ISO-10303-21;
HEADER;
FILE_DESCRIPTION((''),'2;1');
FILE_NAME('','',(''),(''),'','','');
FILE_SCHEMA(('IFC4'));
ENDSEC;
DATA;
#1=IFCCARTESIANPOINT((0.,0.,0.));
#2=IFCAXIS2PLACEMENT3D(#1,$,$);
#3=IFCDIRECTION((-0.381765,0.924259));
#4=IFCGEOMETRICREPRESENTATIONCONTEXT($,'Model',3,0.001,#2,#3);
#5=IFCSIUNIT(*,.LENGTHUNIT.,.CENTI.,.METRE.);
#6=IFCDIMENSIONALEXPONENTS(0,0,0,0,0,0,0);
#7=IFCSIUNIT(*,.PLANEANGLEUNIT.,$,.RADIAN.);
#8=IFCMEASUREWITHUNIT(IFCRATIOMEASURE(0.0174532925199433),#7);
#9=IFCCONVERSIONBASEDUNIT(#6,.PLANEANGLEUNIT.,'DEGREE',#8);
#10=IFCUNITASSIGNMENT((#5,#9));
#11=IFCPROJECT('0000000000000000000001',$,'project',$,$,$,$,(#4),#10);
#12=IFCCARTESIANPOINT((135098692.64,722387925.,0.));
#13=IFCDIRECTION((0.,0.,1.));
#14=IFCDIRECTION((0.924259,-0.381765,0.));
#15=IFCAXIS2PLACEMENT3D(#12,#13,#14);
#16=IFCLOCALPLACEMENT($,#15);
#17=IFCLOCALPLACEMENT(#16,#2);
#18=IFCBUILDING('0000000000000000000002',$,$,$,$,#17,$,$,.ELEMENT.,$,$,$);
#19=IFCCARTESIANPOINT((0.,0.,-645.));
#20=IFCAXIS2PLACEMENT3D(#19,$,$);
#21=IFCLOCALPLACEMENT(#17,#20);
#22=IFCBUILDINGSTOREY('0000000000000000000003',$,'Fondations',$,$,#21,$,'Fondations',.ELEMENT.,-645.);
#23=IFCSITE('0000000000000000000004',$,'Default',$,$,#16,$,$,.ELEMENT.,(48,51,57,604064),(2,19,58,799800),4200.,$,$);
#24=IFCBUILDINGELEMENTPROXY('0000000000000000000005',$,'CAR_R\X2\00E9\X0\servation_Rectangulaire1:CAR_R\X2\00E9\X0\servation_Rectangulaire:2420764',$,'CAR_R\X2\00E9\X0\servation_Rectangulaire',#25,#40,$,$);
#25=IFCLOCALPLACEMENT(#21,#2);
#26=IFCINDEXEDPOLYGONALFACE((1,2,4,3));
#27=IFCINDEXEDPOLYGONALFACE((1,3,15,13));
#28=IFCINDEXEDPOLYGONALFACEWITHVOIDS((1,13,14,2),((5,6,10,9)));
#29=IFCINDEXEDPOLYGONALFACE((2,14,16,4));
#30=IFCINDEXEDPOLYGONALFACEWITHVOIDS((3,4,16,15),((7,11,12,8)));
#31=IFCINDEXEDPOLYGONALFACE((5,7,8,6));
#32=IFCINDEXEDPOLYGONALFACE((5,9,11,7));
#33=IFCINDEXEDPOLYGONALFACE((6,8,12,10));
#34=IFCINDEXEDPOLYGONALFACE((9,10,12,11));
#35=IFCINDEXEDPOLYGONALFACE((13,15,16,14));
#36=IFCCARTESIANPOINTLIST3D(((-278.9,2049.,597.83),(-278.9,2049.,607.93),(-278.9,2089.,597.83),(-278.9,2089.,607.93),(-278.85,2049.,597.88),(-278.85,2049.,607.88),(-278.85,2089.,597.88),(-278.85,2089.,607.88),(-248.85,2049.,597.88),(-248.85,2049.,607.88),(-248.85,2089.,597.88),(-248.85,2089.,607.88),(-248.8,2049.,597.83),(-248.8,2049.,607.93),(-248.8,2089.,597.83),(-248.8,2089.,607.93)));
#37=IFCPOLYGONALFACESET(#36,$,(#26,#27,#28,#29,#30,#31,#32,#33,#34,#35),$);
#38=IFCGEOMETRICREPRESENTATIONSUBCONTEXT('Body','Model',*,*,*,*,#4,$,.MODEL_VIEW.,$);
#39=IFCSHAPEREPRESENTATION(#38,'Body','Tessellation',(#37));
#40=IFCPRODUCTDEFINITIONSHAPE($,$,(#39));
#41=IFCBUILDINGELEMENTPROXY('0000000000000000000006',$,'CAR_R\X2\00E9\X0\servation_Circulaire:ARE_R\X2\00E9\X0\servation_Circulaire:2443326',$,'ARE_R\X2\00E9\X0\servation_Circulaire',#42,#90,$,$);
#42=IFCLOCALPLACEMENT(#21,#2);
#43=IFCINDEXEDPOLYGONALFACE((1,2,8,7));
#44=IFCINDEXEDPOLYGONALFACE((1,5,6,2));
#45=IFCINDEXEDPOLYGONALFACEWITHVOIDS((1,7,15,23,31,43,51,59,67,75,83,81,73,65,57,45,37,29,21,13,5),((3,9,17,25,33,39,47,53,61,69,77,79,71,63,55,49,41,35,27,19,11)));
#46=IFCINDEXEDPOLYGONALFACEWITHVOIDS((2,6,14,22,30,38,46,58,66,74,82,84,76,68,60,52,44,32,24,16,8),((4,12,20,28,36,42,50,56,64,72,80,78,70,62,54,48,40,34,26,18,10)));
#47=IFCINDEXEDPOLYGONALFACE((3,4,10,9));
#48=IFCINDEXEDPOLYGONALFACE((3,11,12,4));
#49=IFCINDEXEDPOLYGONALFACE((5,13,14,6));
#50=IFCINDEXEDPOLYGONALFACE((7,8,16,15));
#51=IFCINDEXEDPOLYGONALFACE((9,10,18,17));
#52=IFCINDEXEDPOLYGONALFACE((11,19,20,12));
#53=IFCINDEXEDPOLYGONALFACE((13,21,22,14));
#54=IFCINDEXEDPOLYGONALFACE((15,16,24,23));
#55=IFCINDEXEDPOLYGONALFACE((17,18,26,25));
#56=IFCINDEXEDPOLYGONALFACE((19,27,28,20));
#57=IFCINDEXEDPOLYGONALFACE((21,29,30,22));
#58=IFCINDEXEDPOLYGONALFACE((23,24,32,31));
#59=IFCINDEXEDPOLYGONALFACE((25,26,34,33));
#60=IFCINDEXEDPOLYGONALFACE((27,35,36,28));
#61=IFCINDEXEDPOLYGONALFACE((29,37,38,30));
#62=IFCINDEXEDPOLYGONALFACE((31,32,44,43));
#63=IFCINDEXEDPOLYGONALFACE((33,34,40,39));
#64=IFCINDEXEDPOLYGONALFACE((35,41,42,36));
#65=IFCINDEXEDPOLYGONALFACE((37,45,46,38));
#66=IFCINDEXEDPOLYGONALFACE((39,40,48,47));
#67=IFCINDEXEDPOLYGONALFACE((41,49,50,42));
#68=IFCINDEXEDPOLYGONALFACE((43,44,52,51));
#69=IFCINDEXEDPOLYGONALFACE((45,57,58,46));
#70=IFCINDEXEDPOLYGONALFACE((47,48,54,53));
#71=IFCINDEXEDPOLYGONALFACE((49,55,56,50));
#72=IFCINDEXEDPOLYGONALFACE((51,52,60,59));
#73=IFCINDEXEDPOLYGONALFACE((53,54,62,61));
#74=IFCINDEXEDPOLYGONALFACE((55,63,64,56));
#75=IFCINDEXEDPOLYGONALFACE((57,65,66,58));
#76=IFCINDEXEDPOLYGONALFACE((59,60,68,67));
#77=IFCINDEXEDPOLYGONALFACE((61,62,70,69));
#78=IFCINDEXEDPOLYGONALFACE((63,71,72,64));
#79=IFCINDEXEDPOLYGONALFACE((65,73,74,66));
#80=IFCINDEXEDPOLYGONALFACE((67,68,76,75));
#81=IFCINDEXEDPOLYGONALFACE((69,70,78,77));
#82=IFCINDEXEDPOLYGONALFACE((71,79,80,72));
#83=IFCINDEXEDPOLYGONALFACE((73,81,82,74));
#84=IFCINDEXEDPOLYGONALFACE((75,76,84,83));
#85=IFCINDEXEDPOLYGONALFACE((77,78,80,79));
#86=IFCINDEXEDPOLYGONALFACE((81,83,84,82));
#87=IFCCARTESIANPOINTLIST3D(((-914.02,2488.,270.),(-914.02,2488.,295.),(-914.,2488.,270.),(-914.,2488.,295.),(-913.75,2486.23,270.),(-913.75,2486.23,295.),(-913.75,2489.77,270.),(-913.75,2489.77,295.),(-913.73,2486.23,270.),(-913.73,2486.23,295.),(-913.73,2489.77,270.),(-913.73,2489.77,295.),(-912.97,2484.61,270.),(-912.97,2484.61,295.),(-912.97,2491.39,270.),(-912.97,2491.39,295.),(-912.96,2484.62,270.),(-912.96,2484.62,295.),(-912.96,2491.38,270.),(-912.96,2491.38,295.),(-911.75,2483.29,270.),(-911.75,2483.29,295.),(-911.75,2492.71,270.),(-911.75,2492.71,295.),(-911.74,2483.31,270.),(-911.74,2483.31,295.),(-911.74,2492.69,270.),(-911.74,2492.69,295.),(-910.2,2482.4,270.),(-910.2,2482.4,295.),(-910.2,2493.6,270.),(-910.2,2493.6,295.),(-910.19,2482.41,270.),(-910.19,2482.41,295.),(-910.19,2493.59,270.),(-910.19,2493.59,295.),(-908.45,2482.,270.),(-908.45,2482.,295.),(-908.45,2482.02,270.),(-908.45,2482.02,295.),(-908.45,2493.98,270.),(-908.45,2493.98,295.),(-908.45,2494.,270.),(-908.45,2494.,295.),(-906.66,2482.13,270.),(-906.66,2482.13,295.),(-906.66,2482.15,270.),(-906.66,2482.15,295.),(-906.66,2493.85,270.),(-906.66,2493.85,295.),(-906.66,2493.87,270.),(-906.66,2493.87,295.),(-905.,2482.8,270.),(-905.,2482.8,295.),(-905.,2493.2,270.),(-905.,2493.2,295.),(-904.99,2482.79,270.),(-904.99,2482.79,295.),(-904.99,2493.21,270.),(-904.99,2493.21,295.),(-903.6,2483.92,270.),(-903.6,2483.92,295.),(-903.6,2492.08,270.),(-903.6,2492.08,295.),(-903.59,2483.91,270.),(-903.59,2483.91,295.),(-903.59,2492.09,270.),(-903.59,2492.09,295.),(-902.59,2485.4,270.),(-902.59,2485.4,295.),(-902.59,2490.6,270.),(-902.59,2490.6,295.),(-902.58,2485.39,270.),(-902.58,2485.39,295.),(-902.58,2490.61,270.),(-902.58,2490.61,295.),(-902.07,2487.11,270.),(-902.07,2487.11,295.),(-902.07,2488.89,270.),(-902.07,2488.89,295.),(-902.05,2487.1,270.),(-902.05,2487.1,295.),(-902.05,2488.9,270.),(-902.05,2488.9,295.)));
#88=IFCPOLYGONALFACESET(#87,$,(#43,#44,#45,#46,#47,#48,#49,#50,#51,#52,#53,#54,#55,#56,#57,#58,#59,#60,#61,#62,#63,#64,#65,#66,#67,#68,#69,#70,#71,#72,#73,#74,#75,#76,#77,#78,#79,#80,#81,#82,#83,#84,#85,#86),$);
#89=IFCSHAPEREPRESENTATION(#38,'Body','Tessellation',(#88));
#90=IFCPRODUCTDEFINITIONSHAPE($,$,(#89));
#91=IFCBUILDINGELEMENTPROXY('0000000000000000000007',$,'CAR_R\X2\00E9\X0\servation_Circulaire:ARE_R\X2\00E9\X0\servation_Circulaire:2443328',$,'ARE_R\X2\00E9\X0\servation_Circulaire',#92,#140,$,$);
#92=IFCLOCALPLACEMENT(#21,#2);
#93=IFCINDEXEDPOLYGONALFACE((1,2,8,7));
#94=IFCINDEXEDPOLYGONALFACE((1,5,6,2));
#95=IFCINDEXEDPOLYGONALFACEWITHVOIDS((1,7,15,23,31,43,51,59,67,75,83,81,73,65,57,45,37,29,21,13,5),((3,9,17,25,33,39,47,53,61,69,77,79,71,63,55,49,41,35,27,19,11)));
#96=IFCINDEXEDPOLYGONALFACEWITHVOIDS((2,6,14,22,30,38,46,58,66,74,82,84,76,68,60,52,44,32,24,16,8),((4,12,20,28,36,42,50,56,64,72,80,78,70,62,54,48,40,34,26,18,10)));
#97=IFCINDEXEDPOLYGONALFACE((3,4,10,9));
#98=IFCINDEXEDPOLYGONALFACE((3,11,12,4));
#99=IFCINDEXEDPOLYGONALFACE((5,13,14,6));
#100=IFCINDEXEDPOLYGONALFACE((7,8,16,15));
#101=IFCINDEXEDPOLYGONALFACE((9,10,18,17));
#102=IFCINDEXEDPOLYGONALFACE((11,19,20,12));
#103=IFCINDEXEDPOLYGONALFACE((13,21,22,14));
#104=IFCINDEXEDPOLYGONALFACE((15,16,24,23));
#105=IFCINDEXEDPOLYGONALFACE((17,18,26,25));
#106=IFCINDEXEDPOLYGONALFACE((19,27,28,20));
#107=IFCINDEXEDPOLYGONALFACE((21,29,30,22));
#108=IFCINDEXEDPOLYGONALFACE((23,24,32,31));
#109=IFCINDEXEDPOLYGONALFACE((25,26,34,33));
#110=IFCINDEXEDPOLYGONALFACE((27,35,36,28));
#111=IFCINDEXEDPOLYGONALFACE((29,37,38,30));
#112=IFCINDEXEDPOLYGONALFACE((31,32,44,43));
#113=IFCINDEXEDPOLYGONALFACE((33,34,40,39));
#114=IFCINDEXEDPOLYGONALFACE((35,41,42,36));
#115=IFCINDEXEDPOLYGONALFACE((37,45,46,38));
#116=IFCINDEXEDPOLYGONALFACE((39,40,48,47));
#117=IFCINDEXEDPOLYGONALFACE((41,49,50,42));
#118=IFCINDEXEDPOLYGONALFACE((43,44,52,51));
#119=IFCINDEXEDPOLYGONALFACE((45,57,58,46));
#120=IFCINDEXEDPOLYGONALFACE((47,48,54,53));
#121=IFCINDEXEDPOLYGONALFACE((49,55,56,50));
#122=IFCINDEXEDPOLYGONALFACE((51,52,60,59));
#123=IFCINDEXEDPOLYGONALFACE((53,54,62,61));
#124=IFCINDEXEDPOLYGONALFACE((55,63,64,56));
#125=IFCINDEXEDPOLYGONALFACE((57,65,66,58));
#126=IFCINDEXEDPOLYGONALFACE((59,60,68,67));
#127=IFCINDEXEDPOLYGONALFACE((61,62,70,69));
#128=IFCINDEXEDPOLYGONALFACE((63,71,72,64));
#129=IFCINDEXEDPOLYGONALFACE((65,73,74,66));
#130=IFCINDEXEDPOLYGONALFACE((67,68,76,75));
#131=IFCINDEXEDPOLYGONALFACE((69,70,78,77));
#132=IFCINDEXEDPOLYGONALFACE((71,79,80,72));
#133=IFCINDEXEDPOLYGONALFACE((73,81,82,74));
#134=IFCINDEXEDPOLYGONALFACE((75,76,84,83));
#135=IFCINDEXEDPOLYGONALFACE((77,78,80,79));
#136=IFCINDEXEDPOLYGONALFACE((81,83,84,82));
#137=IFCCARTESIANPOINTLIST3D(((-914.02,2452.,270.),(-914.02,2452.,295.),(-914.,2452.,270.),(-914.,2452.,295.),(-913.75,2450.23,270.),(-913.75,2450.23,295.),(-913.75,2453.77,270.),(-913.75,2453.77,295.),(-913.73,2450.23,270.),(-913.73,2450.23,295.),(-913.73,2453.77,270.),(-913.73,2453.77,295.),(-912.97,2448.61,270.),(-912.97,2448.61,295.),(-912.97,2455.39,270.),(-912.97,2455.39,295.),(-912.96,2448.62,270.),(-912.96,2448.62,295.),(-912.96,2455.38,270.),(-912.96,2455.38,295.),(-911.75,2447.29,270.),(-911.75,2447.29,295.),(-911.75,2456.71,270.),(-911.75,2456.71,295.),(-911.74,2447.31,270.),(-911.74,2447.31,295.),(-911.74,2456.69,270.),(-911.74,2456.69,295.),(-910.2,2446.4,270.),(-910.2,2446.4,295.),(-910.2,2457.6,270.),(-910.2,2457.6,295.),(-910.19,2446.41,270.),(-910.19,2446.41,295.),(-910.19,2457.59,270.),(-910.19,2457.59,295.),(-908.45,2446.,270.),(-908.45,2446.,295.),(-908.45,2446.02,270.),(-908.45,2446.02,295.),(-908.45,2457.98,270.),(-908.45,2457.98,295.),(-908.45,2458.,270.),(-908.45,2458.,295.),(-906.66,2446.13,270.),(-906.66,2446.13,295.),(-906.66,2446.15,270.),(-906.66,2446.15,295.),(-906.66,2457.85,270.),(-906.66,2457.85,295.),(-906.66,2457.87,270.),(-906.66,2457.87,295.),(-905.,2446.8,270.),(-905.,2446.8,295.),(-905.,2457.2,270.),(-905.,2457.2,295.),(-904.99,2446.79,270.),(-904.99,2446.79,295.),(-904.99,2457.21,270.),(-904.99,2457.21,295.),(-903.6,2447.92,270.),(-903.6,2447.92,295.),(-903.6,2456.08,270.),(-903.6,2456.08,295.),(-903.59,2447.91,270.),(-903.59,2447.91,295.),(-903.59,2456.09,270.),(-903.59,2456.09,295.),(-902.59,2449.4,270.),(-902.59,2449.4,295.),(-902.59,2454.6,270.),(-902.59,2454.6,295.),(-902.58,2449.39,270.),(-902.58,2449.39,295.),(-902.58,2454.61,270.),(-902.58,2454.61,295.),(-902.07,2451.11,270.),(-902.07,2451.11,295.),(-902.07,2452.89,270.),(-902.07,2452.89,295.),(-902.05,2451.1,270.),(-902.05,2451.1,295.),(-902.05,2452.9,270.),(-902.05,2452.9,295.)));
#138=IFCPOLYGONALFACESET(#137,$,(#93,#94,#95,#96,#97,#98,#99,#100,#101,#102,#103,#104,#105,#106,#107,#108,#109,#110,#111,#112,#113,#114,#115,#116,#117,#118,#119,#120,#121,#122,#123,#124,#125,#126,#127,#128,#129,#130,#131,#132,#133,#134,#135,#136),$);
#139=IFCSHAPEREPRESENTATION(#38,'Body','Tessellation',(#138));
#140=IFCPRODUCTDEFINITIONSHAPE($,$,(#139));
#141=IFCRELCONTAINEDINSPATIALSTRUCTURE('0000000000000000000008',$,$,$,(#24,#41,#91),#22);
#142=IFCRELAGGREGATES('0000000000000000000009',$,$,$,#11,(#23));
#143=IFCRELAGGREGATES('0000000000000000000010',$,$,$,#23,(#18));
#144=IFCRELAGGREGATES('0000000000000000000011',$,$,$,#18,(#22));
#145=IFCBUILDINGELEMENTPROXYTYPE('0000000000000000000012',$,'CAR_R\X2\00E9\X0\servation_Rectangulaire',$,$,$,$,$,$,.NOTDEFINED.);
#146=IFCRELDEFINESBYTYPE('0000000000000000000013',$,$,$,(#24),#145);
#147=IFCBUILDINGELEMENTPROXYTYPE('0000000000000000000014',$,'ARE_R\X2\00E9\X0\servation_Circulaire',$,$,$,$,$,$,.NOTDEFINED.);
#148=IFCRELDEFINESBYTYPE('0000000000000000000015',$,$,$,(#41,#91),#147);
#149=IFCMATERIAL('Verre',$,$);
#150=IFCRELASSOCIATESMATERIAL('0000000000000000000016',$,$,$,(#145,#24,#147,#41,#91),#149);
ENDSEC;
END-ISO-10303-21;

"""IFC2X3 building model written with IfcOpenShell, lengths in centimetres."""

from ifc_helpers import new_model, entity, si_unit, converted_unit, direction, frame, frame_2d, origin, place, context, subcontext, project, spatial, polyline, hollow_circle, outline, extrude, source, transform, mapped, material, type_object, type_shapes, element, save


model = new_model("IFC2X3")

# Units and contexts
model_context = context("Model", 3, precision=0.001, world=origin(), true_north=direction((-0.381765, 0.924259)))
body_context = subcontext(model_context, "Body", "Model", "MODEL_VIEW")
ifc_project = project(units=[si_unit("LENGTHUNIT", "METRE", prefix="CENTI"), converted_unit("PLANEANGLEUNIT", "DEGREE", entity("IfcRatioMeasure", 0.0174532925199433), si_unit("PLANEANGLEUNIT", "RADIAN"), dimensions=[0, 0, 0, 0, 0, 0, 0])], contexts=[model_context])

# Site, building, storey
site_placement = place(None, frame((135098692.64, 722387925.0, 0.0), z_axis=(0.0, 0.0, 1.0), x_axis=(0.924259, -0.381765, 0.0)))
site = spatial("IfcSite", under=ifc_project, at=site_placement, Name="Default", CompositionType="ELEMENT", RefLatitude=(48, 51, 57, 604064), RefLongitude=(2, 19, 58, 799800), RefElevation=4200.0)
building_placement = place(site_placement, origin())
building = spatial("IfcBuilding", under=site, at=building_placement, CompositionType="ELEMENT")
storey_placement = place(building_placement, frame((0.0, 0.0, -645.0)))
storey = spatial("IfcBuildingStorey", under=building, at=storey_placement, Name="Fondations", LongName="Fondations", CompositionType="ELEMENT", Elevation=-645.0)

# Building element proxies
ifc_material_1 = material(Name="Verre")
building_element_proxy_type_1 = type_object("IfcBuildingElementProxyType", Name="CAR_Réservation_Rectangulaire", PredefinedType="NOTDEFINED", material=ifc_material_1)
shared_shape_1 = source(origin(), body_context, "Body", "SweptSolid", [
    extrude(outline(polyline([(-15.05, -5.05), (15.05, -5.05), (15.05, 5.05), (-15.05, 5.05), (-15.05, -5.05)]), holes=[polyline([(15.0, -5.0), (-15.0, -5.0), (-15.0, 5.0), (15.0, 5.0), (15.0, -5.0)])]), frame((0.0, 0.0, -40.0), z_axis=(0.0, 0.0, 1.0), x_axis=(-1.0, 0.0, 0.0)), (0.0, 0.0, 1.0), 40.0),
])
type_shapes(building_element_proxy_type_1, [shared_shape_1])
proxy_1_placement = place(storey_placement, frame((-263.85, 2049.0, 602.88), z_axis=(0.0, -1.0, 0.0), x_axis=(1.0, 0.0, 0.0)))
element("IfcBuildingElementProxy", 1, at=proxy_1_placement, inside=storey, type_object=building_element_proxy_type_1, material=ifc_material_1, Name="CAR_Réservation_Rectangulaire1:CAR_Réservation_Rectangulaire:2420764", ObjectType="CAR_Réservation_Rectangulaire", context=body_context, shape_type="MappedRepresentation", body=[
    mapped(shared_shape_1, transform((0.0, 0.0, 0.0), scale=1.0)),
])
building_element_proxy_type_2 = type_object("IfcBuildingElementProxyType", Name="ARE_Réservation_Circulaire", PredefinedType="NOTDEFINED", material=ifc_material_1)
shared_shape_2 = source(origin(), body_context, "Body", "SweptSolid", [
    extrude(hollow_circle(Radius=6.02, WallThickness=0.02, at=frame_2d((0.0, 0.0), x_axis=(1.0, 0.0))), frame((0.0, 0.0, -25.0)), (0.0, 0.0, 1.0), 25.0),
])
type_shapes(building_element_proxy_type_2, [shared_shape_2])
for number, where, z_axis, x_axis, name in (
    (2, (-908.0, 2488.0, 295.0), (0.0, 0.0, 1.0), (-1.0, 0.0, 0.0), "CAR_Réservation_Circulaire:ARE_Réservation_Circulaire:2443326"),
    (3, (-908.0, 2452.0, 295.0), (0.0, 0.0, 1.0), (-1.0, 0.0, 0.0), "CAR_Réservation_Circulaire:ARE_Réservation_Circulaire:2443328"),
):
    element("IfcBuildingElementProxy", number, at=place(storey_placement, frame(where, z_axis=z_axis, x_axis=x_axis)), inside=storey, type_object=building_element_proxy_type_2, material=ifc_material_1, Name=name, ObjectType="ARE_Réservation_Circulaire", context=body_context, shape_type="MappedRepresentation", body=[
        mapped(shared_shape_2, transform((0.0, 0.0, 0.0), scale=1.0)),
    ])

save(model, "model.ifc")
